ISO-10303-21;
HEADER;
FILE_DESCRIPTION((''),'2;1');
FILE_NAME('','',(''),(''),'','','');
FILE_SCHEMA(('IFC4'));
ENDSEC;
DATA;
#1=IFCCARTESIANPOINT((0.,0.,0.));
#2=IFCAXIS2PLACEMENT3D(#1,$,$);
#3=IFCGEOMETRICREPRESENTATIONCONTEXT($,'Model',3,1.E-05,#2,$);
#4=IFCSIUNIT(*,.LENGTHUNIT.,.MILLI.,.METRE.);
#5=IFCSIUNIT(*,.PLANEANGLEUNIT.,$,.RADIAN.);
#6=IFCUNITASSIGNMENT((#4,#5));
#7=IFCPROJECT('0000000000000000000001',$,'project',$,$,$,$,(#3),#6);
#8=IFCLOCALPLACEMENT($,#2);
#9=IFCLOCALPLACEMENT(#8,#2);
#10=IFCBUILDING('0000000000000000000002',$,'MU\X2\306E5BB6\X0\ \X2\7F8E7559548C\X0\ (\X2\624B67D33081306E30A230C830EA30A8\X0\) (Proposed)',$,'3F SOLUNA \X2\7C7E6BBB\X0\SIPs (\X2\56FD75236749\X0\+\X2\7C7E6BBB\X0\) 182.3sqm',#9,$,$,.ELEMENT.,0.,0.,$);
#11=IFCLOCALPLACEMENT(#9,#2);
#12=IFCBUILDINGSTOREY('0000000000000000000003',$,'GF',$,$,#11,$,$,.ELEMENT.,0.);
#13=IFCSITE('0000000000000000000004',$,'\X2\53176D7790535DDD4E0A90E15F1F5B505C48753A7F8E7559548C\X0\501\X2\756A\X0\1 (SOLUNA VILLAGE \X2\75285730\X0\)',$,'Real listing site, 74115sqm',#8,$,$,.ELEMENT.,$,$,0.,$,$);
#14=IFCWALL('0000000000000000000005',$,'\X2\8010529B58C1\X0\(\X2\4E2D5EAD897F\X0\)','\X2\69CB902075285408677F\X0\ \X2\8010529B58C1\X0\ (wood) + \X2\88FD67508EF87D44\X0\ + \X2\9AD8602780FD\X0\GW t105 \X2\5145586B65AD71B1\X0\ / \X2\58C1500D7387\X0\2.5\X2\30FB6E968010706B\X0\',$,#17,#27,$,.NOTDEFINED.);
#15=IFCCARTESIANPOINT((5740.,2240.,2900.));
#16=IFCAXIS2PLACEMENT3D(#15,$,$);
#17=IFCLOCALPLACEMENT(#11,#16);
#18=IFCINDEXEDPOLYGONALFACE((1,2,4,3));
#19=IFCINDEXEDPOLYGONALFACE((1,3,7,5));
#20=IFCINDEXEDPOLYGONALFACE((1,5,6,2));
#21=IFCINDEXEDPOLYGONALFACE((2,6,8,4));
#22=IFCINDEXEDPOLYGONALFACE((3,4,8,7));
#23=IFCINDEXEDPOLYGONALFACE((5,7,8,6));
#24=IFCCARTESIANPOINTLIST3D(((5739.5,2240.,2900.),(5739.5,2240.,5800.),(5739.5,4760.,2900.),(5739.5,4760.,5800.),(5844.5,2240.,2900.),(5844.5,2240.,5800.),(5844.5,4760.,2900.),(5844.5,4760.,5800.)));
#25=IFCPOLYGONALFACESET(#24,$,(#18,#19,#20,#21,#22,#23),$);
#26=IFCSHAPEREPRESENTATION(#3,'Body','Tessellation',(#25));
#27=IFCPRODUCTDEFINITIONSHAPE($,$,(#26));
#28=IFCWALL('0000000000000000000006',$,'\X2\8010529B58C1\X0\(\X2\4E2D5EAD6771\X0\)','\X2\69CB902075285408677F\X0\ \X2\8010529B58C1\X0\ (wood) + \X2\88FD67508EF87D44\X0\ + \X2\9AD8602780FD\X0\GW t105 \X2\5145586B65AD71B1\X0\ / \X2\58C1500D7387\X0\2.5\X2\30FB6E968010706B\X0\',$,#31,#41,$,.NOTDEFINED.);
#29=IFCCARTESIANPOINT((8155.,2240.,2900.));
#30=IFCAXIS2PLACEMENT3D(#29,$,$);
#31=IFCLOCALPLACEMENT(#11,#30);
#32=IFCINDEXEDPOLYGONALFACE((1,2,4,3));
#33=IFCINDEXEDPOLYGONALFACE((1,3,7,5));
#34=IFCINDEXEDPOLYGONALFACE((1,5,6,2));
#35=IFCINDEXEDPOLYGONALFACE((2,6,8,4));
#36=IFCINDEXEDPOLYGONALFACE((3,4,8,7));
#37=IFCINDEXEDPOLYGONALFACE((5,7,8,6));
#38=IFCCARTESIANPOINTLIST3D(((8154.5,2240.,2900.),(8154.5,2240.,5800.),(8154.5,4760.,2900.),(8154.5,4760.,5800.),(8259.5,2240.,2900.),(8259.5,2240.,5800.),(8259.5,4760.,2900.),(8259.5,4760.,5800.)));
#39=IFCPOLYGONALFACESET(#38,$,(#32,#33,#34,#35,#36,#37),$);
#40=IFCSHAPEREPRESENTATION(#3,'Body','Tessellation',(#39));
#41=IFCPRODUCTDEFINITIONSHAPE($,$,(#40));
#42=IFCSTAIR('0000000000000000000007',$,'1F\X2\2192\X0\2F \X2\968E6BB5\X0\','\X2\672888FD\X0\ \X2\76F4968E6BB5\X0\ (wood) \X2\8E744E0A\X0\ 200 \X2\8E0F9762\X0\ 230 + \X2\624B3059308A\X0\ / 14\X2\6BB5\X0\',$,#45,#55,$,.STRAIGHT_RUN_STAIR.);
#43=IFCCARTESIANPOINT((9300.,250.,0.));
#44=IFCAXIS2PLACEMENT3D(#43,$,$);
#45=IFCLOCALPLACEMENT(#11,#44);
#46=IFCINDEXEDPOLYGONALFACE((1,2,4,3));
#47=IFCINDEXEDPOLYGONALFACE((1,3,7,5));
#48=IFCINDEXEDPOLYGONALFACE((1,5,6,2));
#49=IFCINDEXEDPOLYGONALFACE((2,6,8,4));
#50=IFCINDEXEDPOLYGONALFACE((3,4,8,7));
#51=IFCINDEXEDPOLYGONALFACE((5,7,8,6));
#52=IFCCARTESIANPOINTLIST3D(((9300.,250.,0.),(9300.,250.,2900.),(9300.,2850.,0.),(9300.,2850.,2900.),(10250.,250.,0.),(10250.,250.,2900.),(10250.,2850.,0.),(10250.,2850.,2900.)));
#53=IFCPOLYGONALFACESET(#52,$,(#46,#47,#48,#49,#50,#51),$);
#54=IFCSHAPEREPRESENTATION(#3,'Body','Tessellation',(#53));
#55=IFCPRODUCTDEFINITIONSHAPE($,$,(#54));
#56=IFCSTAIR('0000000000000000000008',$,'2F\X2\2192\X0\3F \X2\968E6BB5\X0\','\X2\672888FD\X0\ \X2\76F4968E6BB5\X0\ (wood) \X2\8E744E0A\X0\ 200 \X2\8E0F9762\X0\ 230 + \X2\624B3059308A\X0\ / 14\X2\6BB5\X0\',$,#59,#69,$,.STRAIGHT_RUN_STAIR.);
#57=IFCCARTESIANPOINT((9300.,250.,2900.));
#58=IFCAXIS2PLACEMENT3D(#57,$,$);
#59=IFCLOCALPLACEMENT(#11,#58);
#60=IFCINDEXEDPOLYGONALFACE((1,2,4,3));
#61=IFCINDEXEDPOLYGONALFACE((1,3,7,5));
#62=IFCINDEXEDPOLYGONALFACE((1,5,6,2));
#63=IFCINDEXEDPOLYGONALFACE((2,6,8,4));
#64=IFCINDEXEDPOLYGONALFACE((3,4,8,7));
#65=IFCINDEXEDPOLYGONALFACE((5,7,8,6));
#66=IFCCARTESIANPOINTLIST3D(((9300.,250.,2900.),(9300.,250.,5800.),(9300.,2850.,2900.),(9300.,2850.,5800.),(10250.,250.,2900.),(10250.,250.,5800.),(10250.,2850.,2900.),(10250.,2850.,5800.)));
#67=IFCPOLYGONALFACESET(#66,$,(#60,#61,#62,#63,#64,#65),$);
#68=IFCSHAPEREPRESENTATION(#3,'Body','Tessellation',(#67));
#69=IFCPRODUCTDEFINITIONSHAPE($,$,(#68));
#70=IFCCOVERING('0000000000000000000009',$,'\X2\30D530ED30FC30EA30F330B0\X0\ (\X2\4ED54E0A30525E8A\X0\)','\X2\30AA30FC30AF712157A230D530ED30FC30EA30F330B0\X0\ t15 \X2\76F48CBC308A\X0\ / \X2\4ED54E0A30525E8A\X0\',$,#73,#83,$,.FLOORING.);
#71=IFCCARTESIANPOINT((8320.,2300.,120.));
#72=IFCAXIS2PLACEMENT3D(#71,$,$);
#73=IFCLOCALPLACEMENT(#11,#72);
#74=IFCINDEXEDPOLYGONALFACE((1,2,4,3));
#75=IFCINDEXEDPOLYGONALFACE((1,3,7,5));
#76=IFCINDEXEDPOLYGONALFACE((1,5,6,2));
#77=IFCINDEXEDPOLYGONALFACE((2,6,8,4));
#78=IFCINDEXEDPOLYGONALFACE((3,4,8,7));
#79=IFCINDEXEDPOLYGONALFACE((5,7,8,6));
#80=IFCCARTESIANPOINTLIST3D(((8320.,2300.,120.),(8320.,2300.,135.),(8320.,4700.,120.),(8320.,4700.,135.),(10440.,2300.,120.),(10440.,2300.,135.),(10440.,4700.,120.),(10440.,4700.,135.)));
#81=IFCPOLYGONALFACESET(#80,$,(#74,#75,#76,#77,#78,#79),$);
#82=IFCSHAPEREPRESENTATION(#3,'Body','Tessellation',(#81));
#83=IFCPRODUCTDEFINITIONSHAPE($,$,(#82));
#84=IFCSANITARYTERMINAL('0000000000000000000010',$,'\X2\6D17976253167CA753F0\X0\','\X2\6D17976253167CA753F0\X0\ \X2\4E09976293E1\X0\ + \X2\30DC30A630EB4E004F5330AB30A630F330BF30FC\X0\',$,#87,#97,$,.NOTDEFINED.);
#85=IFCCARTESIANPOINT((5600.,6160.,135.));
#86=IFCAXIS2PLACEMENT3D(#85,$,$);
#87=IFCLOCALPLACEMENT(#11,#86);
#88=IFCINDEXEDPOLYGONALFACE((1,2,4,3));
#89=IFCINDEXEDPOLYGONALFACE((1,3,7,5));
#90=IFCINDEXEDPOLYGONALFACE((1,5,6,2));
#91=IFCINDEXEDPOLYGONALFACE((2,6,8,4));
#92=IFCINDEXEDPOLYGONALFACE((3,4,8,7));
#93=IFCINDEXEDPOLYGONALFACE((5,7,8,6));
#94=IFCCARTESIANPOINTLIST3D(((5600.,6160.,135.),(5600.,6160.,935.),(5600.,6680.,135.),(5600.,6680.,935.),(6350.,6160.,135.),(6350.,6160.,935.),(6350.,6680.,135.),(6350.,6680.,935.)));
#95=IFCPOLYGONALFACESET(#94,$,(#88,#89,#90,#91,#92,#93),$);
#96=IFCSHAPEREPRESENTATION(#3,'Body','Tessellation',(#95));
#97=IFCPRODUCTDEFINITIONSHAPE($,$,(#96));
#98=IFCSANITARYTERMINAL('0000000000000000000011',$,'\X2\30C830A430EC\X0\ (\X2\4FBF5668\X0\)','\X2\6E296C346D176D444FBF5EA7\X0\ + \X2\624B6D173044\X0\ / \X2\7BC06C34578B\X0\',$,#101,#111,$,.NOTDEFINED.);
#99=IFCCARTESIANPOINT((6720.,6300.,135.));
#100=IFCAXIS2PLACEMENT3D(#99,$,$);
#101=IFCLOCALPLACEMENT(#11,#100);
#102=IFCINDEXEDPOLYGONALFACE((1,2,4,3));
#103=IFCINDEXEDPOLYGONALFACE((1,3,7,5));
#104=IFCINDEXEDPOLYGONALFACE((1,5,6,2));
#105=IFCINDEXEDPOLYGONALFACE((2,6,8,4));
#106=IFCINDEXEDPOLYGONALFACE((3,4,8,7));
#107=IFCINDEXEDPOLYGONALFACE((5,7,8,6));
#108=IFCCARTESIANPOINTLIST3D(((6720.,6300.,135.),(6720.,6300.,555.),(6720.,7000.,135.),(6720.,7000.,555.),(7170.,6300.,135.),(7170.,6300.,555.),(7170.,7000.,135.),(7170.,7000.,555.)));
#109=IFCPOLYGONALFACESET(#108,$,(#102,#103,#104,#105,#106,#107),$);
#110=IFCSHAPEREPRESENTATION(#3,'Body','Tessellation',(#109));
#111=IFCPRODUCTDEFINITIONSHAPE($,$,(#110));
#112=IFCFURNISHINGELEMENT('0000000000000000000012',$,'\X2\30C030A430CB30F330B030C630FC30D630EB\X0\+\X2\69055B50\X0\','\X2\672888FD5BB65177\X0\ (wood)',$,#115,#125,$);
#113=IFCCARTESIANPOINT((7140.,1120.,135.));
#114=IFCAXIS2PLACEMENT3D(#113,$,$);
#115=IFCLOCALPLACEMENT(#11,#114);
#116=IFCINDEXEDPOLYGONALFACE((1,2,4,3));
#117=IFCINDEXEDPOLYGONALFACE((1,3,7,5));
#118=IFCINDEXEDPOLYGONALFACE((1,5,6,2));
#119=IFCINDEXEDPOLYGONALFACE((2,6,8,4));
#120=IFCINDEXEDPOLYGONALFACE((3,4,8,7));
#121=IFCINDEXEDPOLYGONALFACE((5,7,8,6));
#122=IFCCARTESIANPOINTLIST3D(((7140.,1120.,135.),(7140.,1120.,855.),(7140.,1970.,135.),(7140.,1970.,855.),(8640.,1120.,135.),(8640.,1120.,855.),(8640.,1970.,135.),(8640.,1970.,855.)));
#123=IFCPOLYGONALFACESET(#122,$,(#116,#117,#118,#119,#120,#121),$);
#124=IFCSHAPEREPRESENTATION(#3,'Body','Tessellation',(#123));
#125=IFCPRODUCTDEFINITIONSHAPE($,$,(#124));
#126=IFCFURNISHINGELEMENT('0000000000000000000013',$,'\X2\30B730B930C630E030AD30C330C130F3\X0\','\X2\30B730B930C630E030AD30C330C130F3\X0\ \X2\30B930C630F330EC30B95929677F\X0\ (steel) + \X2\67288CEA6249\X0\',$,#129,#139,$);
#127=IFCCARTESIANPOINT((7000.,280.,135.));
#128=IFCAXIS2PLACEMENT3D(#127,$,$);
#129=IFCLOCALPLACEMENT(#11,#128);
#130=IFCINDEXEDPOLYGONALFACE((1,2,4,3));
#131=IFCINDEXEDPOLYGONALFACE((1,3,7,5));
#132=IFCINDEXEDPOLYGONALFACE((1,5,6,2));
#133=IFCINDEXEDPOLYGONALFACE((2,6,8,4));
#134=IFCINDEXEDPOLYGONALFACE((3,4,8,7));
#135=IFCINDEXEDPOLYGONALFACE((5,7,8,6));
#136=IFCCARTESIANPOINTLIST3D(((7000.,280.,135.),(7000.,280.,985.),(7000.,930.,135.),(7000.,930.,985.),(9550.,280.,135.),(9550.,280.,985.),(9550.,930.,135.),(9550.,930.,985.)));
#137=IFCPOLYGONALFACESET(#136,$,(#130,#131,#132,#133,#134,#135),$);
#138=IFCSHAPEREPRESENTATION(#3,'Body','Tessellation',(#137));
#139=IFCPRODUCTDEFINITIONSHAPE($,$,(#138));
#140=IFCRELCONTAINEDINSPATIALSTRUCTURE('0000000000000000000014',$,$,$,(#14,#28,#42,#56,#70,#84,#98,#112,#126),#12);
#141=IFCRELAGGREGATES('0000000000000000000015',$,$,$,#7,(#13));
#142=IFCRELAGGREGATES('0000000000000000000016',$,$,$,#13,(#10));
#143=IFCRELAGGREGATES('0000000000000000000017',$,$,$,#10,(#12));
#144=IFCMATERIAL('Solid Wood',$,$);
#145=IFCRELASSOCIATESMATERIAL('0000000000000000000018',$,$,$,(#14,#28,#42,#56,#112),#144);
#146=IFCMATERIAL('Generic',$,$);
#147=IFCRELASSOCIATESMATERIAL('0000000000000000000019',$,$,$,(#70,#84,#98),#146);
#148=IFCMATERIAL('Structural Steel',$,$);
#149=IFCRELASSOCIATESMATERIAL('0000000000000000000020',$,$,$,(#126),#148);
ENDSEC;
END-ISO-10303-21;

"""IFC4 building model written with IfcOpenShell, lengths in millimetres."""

from ifc_helpers import new_model, si_unit, frame, frame_2d, origin, place, context, project, spatial, rectangle, extrude, material, element, save


model = new_model("IFC4")

# Units and contexts
model_context = context("Model", 3, precision=1e-05, world=origin())
ifc_project = project(units=[si_unit("LENGTHUNIT", "METRE", prefix="MILLI"), si_unit("PLANEANGLEUNIT", "RADIAN")], contexts=[model_context])

# Site, building, storey
site_placement = place(None, origin())
site = spatial("IfcSite", under=ifc_project, at=site_placement, Name="北海道川上郡弟子屈町美留和501番1 (SOLUNA VILLAGE 用地)", ObjectType="Real listing site, 74115sqm", CompositionType="ELEMENT", RefElevation=0.0)
building_placement = place(site_placement, origin())
building = spatial("IfcBuilding", under=site, at=building_placement, Name="MUの家 美留和 (手染めのアトリエ) (Proposed)", ObjectType="3F SOLUNA 籾殻SIPs (国産杉+籾殻) 182.3sqm", CompositionType="ELEMENT", ElevationOfRefHeight=0.0, ElevationOfTerrain=0.0)
storey_placement = place(building_placement, origin())
storey = spatial("IfcBuildingStorey", under=building, at=storey_placement, Name="GF", CompositionType="ELEMENT", Elevation=0.0)

# Shared definitions
ifc_material_1 = material(Name="Solid Wood")

# Walls
wall_1_placement = place(storey_placement, frame((5740.0, 2240.0, 2900.0)))
element("IfcWall", 1, at=wall_1_placement, inside=storey, material=ifc_material_1, Name="耐力壁(中庭西)", Description="構造用合板 耐力壁 (wood) + 製材軸組 + 高性能GW t105 充填断熱 / 壁倍率2.5・準耐火", PredefinedType="NOTDEFINED", context=model_context, shape_type="SweptSolid", body=[
    extrude(rectangle(XDim=105.0, YDim=2520.0, at=frame_2d((52.0, 1260.0))), frame((5740.0, 2240.0, 2900.0)), (0.0, 0.0, 1.0), 2900.0),
])
wall_2_placement = place(storey_placement, frame((8155.0, 2240.0, 2900.0)))
element("IfcWall", 2, at=wall_2_placement, inside=storey, material=ifc_material_1, Name="耐力壁(中庭東)", Description="構造用合板 耐力壁 (wood) + 製材軸組 + 高性能GW t105 充填断熱 / 壁倍率2.5・準耐火", PredefinedType="NOTDEFINED", context=model_context, shape_type="SweptSolid", body=[
    extrude(rectangle(XDim=105.0, YDim=2520.0, at=frame_2d((52.0, 1260.0))), frame((8155.0, 2240.0, 2900.0)), (0.0, 0.0, 1.0), 2900.0),
])

# Stairs
stair_1_placement = place(storey_placement, frame((9300.0, 250.0, 0.0)))
element("IfcStair", 3, at=stair_1_placement, inside=storey, material=ifc_material_1, Name="1F→2F 階段", Description="木製 直階段 (wood) 蹴上 200 踏面 230 + 手すり / 14段", PredefinedType="STRAIGHT_RUN_STAIR", context=model_context, shape_type="SweptSolid", body=[
    extrude(rectangle(XDim=950.0, YDim=2600.0, at=frame_2d((475.0, 1300.0))), frame((9300.0, 250.0, 0.0)), (0.0, 0.0, 1.0), 2900.0),
])
stair_2_placement = place(storey_placement, frame((9300.0, 250.0, 2900.0)))
element("IfcStair", 4, at=stair_2_placement, inside=storey, material=ifc_material_1, Name="2F→3F 階段", Description="木製 直階段 (wood) 蹴上 200 踏面 230 + 手すり / 14段", PredefinedType="STRAIGHT_RUN_STAIR", context=model_context, shape_type="SweptSolid", body=[
    extrude(rectangle(XDim=950.0, YDim=2600.0, at=frame_2d((475.0, 1300.0))), frame((9300.0, 250.0, 2900.0)), (0.0, 0.0, 1.0), 2900.0),
])

# Covering
ifc_material_2 = material(Name="Generic")
covering_placement = place(storey_placement, frame((8320.0, 2300.0, 120.0)))
element("IfcCovering", 5, at=covering_placement, inside=storey, material=ifc_material_2, Name="フローリング (仕上げ床)", Description="オーク無垢フローリング t15 直貼り / 仕上げ床", PredefinedType="FLOORING", context=model_context, shape_type="SweptSolid", body=[
    extrude(rectangle(XDim=2120.0, YDim=2400.0, at=frame_2d((1060.0, 1200.0))), frame((8320.0, 2300.0, 120.0)), (0.0, 0.0, 1.0), 15.0),
])

# Sanitary terminals
sanitary_terminal_1_placement = place(storey_placement, frame((5600.0, 6160.0, 135.0)))
element("IfcSanitaryTerminal", 6, at=sanitary_terminal_1_placement, inside=storey, material=ifc_material_2, Name="洗面化粧台", Description="洗面化粧台 三面鏡 + ボウル一体カウンター", PredefinedType="NOTDEFINED", context=model_context, shape_type="SweptSolid", body=[
    extrude(rectangle(XDim=750.0, YDim=520.0, at=frame_2d((375.0, 260.0))), frame((5600.0, 6160.0, 135.0)), (0.0, 0.0, 1.0), 800.0),
])
sanitary_terminal_2_placement = place(storey_placement, frame((6720.0, 6300.0, 135.0)))
element("IfcSanitaryTerminal", 7, at=sanitary_terminal_2_placement, inside=storey, material=ifc_material_2, Name="トイレ (便器)", Description="温水洗浄便座 + 手洗い / 節水型", PredefinedType="NOTDEFINED", context=model_context, shape_type="SweptSolid", body=[
    extrude(rectangle(XDim=450.0, YDim=700.0, at=frame_2d((225.0, 350.0))), frame((6720.0, 6300.0, 135.0)), (0.0, 0.0, 1.0), 420.0),
])

# Furnishing elements
furnishing_1_placement = place(storey_placement, frame((7140.0, 1120.0, 135.0)))
element("IfcFurnishingElement", 8, at=furnishing_1_placement, inside=storey, material=ifc_material_1, Name="ダイニングテーブル+椅子", Description="木製家具 (wood)", context=model_context, shape_type="SweptSolid", body=[
    extrude(rectangle(XDim=1500.0, YDim=850.0, at=frame_2d((750.0, 425.0))), frame((7140.0, 1120.0, 135.0)), (0.0, 0.0, 1.0), 720.0),
])
ifc_material_3 = material(Name="Structural Steel")
furnishing_2_placement = place(storey_placement, frame((7000.0, 280.0, 135.0)))
element("IfcFurnishingElement", 9, at=furnishing_2_placement, inside=storey, material=ifc_material_3, Name="システムキッチン", Description="システムキッチン ステンレス天板 (steel) + 木質扉", context=model_context, shape_type="SweptSolid", body=[
    extrude(rectangle(XDim=2550.0, YDim=650.0, at=frame_2d((1275.0, 325.0))), frame((7000.0, 280.0, 135.0)), (0.0, 0.0, 1.0), 850.0),
])

save(model, "model.ifc")
